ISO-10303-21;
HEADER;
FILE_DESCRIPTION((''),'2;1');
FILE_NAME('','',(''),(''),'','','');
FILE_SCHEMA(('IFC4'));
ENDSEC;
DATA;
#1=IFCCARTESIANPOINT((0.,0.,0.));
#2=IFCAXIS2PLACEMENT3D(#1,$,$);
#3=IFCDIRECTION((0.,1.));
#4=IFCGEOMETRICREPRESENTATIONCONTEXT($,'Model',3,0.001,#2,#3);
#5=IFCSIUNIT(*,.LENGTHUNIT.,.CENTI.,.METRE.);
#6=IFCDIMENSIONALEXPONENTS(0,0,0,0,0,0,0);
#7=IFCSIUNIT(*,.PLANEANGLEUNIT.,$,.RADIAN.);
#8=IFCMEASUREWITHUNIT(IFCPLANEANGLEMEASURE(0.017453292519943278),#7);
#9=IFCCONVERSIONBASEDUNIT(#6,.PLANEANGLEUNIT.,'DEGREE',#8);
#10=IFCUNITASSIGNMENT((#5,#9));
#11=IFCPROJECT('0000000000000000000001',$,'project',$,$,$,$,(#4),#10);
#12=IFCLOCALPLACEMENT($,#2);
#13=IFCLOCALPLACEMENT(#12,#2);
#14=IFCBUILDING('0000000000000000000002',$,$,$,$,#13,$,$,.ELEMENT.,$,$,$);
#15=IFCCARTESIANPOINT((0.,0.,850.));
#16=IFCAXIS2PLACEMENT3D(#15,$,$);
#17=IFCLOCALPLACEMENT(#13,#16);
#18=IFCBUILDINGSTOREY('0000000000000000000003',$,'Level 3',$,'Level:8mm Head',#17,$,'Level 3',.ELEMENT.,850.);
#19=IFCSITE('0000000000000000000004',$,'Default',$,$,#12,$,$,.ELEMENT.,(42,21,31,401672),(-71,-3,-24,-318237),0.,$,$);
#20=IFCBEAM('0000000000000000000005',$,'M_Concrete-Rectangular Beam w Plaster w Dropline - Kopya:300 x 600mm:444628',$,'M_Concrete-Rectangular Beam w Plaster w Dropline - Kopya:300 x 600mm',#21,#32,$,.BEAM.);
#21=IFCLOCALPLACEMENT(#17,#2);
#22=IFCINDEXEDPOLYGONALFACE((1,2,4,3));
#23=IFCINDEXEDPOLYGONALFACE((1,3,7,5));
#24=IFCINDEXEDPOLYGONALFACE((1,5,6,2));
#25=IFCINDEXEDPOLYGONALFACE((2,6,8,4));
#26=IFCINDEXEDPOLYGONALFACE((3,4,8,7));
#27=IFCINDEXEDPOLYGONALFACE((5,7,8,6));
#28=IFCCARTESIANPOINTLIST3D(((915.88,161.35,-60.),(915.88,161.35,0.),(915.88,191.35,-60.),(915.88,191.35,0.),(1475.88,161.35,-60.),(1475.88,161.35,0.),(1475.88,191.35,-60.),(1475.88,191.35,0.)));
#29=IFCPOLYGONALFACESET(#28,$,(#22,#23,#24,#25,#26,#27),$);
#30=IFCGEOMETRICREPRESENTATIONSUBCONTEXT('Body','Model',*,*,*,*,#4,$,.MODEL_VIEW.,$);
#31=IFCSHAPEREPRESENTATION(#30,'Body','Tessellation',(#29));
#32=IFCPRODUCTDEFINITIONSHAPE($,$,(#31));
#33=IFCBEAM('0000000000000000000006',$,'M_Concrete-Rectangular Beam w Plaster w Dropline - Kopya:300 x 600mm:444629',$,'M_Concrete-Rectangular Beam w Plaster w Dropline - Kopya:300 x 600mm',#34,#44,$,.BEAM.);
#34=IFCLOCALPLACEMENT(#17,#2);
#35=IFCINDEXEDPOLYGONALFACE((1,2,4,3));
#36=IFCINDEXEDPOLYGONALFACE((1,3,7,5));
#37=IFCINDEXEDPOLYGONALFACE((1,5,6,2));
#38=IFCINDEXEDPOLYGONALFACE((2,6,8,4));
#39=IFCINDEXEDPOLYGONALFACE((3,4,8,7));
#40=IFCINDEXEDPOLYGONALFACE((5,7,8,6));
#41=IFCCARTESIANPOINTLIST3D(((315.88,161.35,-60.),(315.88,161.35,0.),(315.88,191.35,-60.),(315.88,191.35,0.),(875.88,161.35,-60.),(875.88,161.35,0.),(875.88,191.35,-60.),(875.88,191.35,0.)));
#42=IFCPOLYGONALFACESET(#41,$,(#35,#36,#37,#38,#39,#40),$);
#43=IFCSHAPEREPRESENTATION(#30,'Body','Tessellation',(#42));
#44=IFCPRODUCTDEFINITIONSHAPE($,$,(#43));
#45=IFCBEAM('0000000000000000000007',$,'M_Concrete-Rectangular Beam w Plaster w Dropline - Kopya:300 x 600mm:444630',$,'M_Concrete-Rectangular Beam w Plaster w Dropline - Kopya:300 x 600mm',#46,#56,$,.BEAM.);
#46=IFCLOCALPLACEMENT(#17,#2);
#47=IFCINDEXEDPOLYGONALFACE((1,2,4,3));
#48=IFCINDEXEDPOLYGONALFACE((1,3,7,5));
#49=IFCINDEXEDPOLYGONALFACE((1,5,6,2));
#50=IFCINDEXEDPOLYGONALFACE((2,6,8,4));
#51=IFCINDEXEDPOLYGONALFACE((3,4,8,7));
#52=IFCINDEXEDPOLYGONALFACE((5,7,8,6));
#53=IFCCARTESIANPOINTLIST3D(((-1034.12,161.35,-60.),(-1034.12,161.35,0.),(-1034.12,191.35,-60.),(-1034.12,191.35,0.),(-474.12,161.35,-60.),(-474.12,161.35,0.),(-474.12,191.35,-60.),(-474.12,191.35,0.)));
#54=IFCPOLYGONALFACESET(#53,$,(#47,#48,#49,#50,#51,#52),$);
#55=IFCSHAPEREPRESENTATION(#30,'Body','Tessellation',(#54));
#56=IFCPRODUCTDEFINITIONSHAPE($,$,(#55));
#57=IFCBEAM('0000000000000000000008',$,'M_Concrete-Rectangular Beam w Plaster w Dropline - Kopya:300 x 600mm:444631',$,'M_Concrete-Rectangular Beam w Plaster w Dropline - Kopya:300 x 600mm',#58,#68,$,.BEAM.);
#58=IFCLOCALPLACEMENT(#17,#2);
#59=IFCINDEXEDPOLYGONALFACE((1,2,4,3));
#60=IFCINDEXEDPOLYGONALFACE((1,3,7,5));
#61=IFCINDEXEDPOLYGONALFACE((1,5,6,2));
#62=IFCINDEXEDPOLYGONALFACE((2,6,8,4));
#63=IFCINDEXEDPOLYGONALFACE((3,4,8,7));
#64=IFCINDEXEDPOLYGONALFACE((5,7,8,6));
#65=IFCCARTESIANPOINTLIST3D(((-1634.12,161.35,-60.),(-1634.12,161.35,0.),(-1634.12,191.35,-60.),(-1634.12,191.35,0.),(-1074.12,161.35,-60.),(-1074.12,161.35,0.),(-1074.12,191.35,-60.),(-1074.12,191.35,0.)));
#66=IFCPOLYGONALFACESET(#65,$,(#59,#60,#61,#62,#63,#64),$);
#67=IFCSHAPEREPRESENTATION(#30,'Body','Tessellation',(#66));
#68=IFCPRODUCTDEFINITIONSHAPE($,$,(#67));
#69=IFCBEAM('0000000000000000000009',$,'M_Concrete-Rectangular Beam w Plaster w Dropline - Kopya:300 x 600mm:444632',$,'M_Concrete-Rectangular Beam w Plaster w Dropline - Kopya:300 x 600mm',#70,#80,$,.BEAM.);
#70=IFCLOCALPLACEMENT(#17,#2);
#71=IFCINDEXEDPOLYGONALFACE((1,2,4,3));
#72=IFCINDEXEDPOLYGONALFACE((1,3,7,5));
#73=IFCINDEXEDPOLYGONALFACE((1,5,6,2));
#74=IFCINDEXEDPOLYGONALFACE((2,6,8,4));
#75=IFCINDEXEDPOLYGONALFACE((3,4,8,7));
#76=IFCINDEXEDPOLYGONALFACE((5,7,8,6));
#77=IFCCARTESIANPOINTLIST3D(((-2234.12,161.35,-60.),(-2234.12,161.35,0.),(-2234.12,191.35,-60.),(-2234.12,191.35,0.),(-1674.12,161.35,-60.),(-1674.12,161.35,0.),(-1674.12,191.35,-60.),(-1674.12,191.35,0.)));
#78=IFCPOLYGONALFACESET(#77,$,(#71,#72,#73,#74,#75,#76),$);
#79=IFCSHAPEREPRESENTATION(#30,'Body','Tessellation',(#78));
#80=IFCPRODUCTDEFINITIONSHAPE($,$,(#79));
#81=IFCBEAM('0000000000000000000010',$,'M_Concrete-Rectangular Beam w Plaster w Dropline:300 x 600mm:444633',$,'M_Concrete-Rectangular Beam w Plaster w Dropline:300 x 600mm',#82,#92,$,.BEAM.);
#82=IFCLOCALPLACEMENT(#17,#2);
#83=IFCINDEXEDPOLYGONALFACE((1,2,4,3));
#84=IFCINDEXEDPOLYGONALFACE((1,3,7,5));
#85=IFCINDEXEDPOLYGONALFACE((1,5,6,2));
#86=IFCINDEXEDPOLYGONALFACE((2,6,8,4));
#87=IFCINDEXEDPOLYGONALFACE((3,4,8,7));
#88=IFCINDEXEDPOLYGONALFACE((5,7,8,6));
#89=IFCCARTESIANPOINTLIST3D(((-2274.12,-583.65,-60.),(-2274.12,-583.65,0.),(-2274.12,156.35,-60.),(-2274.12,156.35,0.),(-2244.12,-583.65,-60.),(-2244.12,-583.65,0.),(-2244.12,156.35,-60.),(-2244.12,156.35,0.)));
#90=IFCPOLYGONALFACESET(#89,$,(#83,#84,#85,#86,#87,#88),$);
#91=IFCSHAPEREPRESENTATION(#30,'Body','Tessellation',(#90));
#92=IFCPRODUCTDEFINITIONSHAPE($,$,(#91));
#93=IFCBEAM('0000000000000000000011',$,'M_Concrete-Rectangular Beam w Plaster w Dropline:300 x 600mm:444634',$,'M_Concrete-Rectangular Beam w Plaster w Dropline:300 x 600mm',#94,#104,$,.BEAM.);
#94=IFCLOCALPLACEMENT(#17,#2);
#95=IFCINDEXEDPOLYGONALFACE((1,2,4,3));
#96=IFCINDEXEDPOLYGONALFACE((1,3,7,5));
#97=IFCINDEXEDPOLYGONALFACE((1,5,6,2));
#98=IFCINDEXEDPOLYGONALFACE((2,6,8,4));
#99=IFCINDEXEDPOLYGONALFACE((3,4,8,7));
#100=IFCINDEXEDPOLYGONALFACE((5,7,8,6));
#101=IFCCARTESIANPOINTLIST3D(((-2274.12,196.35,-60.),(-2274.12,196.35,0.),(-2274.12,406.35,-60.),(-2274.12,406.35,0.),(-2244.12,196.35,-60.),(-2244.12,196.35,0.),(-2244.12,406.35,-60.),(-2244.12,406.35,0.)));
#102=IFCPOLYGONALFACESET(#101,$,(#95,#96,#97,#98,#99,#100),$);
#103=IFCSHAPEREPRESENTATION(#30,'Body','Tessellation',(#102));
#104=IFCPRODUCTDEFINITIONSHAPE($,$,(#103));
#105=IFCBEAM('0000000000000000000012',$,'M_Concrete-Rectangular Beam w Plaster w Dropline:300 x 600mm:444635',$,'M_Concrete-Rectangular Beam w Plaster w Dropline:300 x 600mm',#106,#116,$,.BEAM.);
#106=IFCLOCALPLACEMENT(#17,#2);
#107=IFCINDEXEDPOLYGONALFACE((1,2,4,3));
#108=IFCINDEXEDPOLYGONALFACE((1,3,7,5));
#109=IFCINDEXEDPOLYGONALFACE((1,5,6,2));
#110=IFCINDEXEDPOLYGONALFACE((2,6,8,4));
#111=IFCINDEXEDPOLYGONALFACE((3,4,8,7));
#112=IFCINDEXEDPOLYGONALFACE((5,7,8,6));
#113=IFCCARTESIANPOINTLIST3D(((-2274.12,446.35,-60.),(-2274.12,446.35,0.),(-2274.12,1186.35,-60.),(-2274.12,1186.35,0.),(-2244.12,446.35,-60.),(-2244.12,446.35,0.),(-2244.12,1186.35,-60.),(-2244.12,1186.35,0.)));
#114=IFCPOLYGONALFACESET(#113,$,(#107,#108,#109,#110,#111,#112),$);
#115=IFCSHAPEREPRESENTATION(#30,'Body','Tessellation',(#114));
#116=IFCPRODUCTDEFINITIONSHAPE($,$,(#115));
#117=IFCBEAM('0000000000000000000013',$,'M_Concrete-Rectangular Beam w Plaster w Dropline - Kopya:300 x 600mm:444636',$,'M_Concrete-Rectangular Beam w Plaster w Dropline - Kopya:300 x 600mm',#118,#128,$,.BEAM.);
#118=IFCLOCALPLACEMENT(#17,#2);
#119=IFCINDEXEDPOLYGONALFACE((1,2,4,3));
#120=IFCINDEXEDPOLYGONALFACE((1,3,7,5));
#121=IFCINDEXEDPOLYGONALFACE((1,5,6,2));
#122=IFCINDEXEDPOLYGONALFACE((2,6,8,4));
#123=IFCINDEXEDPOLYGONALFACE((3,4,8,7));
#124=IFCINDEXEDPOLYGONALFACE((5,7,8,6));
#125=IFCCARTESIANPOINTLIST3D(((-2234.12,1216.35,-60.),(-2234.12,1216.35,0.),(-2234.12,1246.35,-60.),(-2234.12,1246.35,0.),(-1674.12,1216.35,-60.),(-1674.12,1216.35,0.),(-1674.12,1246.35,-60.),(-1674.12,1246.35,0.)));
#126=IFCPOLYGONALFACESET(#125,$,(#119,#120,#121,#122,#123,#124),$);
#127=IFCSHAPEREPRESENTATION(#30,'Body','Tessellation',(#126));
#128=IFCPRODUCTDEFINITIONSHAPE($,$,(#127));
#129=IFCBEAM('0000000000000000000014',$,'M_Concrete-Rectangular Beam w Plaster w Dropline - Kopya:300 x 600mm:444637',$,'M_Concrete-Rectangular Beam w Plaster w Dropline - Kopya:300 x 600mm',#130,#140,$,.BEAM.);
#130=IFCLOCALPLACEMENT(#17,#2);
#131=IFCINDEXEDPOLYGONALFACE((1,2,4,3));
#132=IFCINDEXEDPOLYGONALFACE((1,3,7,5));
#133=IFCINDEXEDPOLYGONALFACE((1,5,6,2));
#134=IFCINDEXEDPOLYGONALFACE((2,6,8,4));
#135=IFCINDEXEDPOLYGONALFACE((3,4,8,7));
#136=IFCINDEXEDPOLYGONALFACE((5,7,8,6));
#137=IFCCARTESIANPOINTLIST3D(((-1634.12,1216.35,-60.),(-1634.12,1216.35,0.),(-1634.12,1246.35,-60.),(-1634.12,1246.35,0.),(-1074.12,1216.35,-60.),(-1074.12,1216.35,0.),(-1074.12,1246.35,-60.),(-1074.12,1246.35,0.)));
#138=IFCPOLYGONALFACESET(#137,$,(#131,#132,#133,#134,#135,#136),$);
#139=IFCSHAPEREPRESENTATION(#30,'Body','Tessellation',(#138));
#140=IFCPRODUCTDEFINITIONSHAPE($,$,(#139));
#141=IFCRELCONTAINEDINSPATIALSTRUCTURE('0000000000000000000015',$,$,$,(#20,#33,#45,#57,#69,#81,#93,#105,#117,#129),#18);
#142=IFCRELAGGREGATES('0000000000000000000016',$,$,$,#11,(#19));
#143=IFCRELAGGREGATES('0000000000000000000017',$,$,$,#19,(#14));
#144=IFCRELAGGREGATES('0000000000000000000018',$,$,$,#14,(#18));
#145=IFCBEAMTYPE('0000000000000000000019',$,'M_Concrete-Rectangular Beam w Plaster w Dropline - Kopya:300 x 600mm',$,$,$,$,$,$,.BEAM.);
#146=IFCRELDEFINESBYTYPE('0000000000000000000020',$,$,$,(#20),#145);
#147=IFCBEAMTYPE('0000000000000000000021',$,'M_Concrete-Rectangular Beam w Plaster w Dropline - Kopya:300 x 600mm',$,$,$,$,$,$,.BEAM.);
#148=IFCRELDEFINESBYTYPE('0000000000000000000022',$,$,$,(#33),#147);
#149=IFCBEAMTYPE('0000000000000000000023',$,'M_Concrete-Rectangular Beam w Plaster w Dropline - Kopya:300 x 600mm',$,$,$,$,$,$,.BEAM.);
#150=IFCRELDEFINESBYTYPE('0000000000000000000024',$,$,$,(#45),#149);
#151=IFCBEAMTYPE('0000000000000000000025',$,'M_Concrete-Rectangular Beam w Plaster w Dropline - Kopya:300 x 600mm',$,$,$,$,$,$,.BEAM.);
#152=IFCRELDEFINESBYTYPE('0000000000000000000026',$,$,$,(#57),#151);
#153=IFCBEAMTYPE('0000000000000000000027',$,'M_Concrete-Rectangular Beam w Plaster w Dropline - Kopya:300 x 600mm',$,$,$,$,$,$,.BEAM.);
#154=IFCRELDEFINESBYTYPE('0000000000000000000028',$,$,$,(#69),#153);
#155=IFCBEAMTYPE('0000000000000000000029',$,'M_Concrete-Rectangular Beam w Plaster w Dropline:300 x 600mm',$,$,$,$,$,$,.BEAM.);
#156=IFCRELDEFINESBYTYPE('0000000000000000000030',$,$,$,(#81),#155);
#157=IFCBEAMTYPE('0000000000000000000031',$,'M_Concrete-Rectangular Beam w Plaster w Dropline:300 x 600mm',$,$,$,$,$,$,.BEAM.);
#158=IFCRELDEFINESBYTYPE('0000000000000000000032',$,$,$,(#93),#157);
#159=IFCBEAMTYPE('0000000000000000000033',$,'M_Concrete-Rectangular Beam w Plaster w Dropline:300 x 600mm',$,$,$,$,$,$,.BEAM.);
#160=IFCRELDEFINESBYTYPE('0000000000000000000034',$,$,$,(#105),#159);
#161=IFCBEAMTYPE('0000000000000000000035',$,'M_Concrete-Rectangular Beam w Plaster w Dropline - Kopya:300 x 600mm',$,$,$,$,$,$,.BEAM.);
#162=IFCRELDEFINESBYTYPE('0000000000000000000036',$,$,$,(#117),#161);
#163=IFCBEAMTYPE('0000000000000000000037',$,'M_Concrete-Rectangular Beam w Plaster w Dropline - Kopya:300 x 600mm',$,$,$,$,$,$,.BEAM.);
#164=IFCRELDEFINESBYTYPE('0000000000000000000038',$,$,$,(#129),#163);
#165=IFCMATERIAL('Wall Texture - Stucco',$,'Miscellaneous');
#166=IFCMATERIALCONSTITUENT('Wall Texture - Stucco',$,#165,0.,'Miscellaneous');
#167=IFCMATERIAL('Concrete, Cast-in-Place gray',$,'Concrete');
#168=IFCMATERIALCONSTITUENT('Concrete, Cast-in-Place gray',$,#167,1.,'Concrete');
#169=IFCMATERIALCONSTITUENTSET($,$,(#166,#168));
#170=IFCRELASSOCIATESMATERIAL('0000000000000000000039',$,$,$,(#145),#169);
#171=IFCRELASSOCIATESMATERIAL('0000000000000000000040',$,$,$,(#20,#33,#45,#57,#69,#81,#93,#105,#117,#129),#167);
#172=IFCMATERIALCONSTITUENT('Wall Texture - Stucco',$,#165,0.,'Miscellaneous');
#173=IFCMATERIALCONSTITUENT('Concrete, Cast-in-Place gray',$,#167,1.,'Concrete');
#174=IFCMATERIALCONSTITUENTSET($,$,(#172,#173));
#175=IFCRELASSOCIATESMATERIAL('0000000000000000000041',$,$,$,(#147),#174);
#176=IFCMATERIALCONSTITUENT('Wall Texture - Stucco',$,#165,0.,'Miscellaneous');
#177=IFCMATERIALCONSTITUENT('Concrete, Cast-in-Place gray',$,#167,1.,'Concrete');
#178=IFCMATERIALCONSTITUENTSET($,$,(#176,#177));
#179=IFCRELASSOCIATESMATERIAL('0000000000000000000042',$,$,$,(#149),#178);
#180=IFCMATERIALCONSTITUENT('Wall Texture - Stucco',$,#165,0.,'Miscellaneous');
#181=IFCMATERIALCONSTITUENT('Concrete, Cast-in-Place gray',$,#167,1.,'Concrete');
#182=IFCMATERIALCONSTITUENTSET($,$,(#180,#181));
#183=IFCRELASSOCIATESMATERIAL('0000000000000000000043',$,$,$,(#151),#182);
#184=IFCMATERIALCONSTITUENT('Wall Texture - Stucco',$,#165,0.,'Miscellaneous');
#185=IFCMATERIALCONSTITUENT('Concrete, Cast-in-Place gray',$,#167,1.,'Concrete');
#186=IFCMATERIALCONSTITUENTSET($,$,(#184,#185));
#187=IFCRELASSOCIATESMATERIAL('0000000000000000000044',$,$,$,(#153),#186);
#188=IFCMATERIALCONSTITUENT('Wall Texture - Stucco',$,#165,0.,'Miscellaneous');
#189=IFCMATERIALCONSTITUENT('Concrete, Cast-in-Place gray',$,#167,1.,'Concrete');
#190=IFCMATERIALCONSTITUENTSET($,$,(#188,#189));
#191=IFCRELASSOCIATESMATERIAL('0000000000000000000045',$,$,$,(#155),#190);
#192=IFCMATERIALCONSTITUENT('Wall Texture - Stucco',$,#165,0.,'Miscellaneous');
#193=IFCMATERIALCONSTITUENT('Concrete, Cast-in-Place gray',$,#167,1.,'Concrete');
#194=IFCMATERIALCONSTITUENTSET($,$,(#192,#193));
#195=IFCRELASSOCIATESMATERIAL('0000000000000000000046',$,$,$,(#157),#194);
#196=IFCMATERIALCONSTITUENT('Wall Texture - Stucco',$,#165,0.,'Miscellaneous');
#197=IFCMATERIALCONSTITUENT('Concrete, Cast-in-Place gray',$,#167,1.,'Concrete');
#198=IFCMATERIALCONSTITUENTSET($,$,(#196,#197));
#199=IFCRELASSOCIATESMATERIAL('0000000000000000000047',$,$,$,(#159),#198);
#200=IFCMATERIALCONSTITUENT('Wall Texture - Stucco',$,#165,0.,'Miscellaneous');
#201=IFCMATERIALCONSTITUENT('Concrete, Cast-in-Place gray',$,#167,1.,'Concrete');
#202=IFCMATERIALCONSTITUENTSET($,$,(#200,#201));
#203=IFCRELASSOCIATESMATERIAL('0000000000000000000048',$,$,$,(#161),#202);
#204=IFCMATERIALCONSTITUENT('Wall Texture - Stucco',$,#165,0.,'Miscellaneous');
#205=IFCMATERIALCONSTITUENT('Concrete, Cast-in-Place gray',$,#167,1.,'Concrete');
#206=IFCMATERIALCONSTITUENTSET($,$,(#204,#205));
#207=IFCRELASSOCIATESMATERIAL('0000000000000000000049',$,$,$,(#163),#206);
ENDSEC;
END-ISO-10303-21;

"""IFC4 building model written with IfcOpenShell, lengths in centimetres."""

from ifc_helpers import new_model, entity, si_unit, converted_unit, direction, frame, origin, place, context, subcontext, project, spatial, indexed_curve, outline, extrude, source, transform, mapped, material, constituent, constituent_set, type_object, type_shapes, element, save


model = new_model("IFC4")

# Units and contexts
model_context = context("Model", 3, precision=0.001, world=origin(), true_north=direction((0.0, 1.0)))
body_context = subcontext(model_context, "Body", "Model", "MODEL_VIEW")
ifc_project = project(units=[si_unit("LENGTHUNIT", "METRE", prefix="CENTI"), converted_unit("PLANEANGLEUNIT", "DEGREE", entity("IfcPlaneAngleMeasure", 0.017453292519943278), si_unit("PLANEANGLEUNIT", "RADIAN"), dimensions=[0, 0, 0, 0, 0, 0, 0])], contexts=[model_context])

# Site, building, storey
site_placement = place(None, origin())
site = spatial("IfcSite", under=ifc_project, at=site_placement, Name="Default", CompositionType="ELEMENT", RefLatitude=(42, 21, 31, 401672), RefLongitude=(-71, -3, -24, -318237), RefElevation=0.0)
building_placement = place(site_placement, origin())
building = spatial("IfcBuilding", under=site, at=building_placement, CompositionType="ELEMENT")
storey_placement = place(building_placement, frame((0.0, 0.0, 850.0)))
storey = spatial("IfcBuildingStorey", under=building, at=storey_placement, Name="Level 3", ObjectType="Level:8mm Head", LongName="Level 3", CompositionType="ELEMENT", Elevation=850.0)

# Beams
ifc_material_1 = material(Name="Concrete, Cast-in-Place gray", Category="Concrete")
ifc_material_2 = material(Name="Wall Texture - Stucco", Category="Miscellaneous")
ifc_constituent_1 = constituent(ifc_material_2, Name="Wall Texture - Stucco", Category="Miscellaneous", fraction=0.0)
ifc_constituent_2 = constituent(ifc_material_1, Name="Concrete, Cast-in-Place gray", Category="Concrete", fraction=1.0)
ifc_constituent_set_1 = constituent_set(constituents=[ifc_constituent_1, ifc_constituent_2])
beam_type_1 = type_object("IfcBeamType", Name="M_Concrete-Rectangular Beam w Plaster w Dropline - Kopya:300 x 600mm", PredefinedType="BEAM", material=ifc_constituent_set_1)
shared_shape_1 = source(origin(), body_context, "Body", "SweptSolid", [
    extrude(outline(indexed_curve([(-30.0, -15.0), (30.0, -15.0), (30.0, 15.0), (-30.0, 15.0), (-30.0, -15.0)], self_intersect=False)), frame((1475.88, 176.35, 820.0), z_axis=(-1.0, 0.0, 0.0), x_axis=(0.0, 0.0, -1.0)), (0.0, 0.0, 1.0), 560.0),
])
type_shapes(beam_type_1, [shared_shape_1])
beam_1_placement = place(storey_placement, frame((0.0, 0.0, -850.0)))
element("IfcBeam", 1, at=beam_1_placement, inside=storey, type_object=beam_type_1, material=ifc_material_1, Name="M_Concrete-Rectangular Beam w Plaster w Dropline - Kopya:300 x 600mm:444628", ObjectType="M_Concrete-Rectangular Beam w Plaster w Dropline - Kopya:300 x 600mm", PredefinedType="BEAM", context=body_context, shape_type="MappedRepresentation", body=[
    mapped(shared_shape_1, transform((0.0, 0.0, 0.0), scale=1.0)),
])
ifc_constituent_3 = constituent(ifc_material_2, Name="Wall Texture - Stucco", Category="Miscellaneous", fraction=0.0)
ifc_constituent_4 = constituent(ifc_material_1, Name="Concrete, Cast-in-Place gray", Category="Concrete", fraction=1.0)
ifc_constituent_set_2 = constituent_set(constituents=[ifc_constituent_3, ifc_constituent_4])
beam_type_2 = type_object("IfcBeamType", Name="M_Concrete-Rectangular Beam w Plaster w Dropline - Kopya:300 x 600mm", PredefinedType="BEAM", material=ifc_constituent_set_2)
shared_shape_2 = source(origin(), body_context, "Body", "SweptSolid", [
    extrude(outline(indexed_curve([(-30.0, -15.0), (30.0, -15.0), (30.0, 15.0), (-30.0, 15.0), (-30.0, -15.0)], self_intersect=False)), frame((875.88, 176.35, 820.0), z_axis=(-1.0, 0.0, 0.0), x_axis=(0.0, 0.0, -1.0)), (0.0, 0.0, 1.0), 560.0),
])
type_shapes(beam_type_2, [shared_shape_2])
beam_2_placement = place(storey_placement, frame((0.0, 0.0, -850.0)))
element("IfcBeam", 2, at=beam_2_placement, inside=storey, type_object=beam_type_2, material=ifc_material_1, Name="M_Concrete-Rectangular Beam w Plaster w Dropline - Kopya:300 x 600mm:444629", ObjectType="M_Concrete-Rectangular Beam w Plaster w Dropline - Kopya:300 x 600mm", PredefinedType="BEAM", context=body_context, shape_type="MappedRepresentation", body=[
    mapped(shared_shape_2, transform((0.0, 0.0, 0.0), scale=1.0)),
])
ifc_constituent_5 = constituent(ifc_material_2, Name="Wall Texture - Stucco", Category="Miscellaneous", fraction=0.0)
ifc_constituent_6 = constituent(ifc_material_1, Name="Concrete, Cast-in-Place gray", Category="Concrete", fraction=1.0)
ifc_constituent_set_3 = constituent_set(constituents=[ifc_constituent_5, ifc_constituent_6])
beam_type_3 = type_object("IfcBeamType", Name="M_Concrete-Rectangular Beam w Plaster w Dropline - Kopya:300 x 600mm", PredefinedType="BEAM", material=ifc_constituent_set_3)
shared_shape_3 = source(origin(), body_context, "Body", "SweptSolid", [
    extrude(outline(indexed_curve([(-30.0, -15.0), (30.0, -15.0), (30.0, 15.0), (-30.0, 15.0), (-30.0, -15.0)], self_intersect=False)), frame((-474.12, 176.35, 820.0), z_axis=(-1.0, 0.0, 0.0), x_axis=(0.0, 0.0, -1.0)), (0.0, 0.0, 1.0), 560.0),
])
type_shapes(beam_type_3, [shared_shape_3])
beam_3_placement = place(storey_placement, frame((0.0, 0.0, -850.0)))
element("IfcBeam", 3, at=beam_3_placement, inside=storey, type_object=beam_type_3, material=ifc_material_1, Name="M_Concrete-Rectangular Beam w Plaster w Dropline - Kopya:300 x 600mm:444630", ObjectType="M_Concrete-Rectangular Beam w Plaster w Dropline - Kopya:300 x 600mm", PredefinedType="BEAM", context=body_context, shape_type="MappedRepresentation", body=[
    mapped(shared_shape_3, transform((0.0, 0.0, 0.0), scale=1.0)),
])
ifc_constituent_7 = constituent(ifc_material_2, Name="Wall Texture - Stucco", Category="Miscellaneous", fraction=0.0)
ifc_constituent_8 = constituent(ifc_material_1, Name="Concrete, Cast-in-Place gray", Category="Concrete", fraction=1.0)
ifc_constituent_set_4 = constituent_set(constituents=[ifc_constituent_7, ifc_constituent_8])
beam_type_4 = type_object("IfcBeamType", Name="M_Concrete-Rectangular Beam w Plaster w Dropline - Kopya:300 x 600mm", PredefinedType="BEAM", material=ifc_constituent_set_4)
shared_shape_4 = source(origin(), body_context, "Body", "SweptSolid", [
    extrude(outline(indexed_curve([(-30.0, -15.0), (30.0, -15.0), (30.0, 15.0), (-30.0, 15.0), (-30.0, -15.0)], self_intersect=False)), frame((-1074.12, 176.35, 820.0), z_axis=(-1.0, 0.0, 0.0), x_axis=(0.0, 0.0, -1.0)), (0.0, 0.0, 1.0), 560.0),
])
type_shapes(beam_type_4, [shared_shape_4])
beam_4_placement = place(storey_placement, frame((0.0, 0.0, -850.0)))
element("IfcBeam", 4, at=beam_4_placement, inside=storey, type_object=beam_type_4, material=ifc_material_1, Name="M_Concrete-Rectangular Beam w Plaster w Dropline - Kopya:300 x 600mm:444631", ObjectType="M_Concrete-Rectangular Beam w Plaster w Dropline - Kopya:300 x 600mm", PredefinedType="BEAM", context=body_context, shape_type="MappedRepresentation", body=[
    mapped(shared_shape_4, transform((0.0, 0.0, 0.0), scale=1.0)),
])
ifc_constituent_9 = constituent(ifc_material_2, Name="Wall Texture - Stucco", Category="Miscellaneous", fraction=0.0)
ifc_constituent_10 = constituent(ifc_material_1, Name="Concrete, Cast-in-Place gray", Category="Concrete", fraction=1.0)
ifc_constituent_set_5 = constituent_set(constituents=[ifc_constituent_9, ifc_constituent_10])
beam_type_5 = type_object("IfcBeamType", Name="M_Concrete-Rectangular Beam w Plaster w Dropline - Kopya:300 x 600mm", PredefinedType="BEAM", material=ifc_constituent_set_5)
shared_shape_5 = source(origin(), body_context, "Body", "SweptSolid", [
    extrude(outline(indexed_curve([(-30.0, -15.0), (30.0, -15.0), (30.0, 15.0), (-30.0, 15.0), (-30.0, -15.0)], self_intersect=False)), frame((-1674.12, 176.35, 820.0), z_axis=(-1.0, 0.0, 0.0), x_axis=(0.0, 0.0, -1.0)), (0.0, 0.0, 1.0), 560.0),
])
type_shapes(beam_type_5, [shared_shape_5])
beam_5_placement = place(storey_placement, frame((0.0, 0.0, -850.0)))
element("IfcBeam", 5, at=beam_5_placement, inside=storey, type_object=beam_type_5, material=ifc_material_1, Name="M_Concrete-Rectangular Beam w Plaster w Dropline - Kopya:300 x 600mm:444632", ObjectType="M_Concrete-Rectangular Beam w Plaster w Dropline - Kopya:300 x 600mm", PredefinedType="BEAM", context=body_context, shape_type="MappedRepresentation", body=[
    mapped(shared_shape_5, transform((0.0, 0.0, 0.0), scale=1.0)),
])
ifc_constituent_11 = constituent(ifc_material_2, Name="Wall Texture - Stucco", Category="Miscellaneous", fraction=0.0)
ifc_constituent_12 = constituent(ifc_material_1, Name="Concrete, Cast-in-Place gray", Category="Concrete", fraction=1.0)
ifc_constituent_set_6 = constituent_set(constituents=[ifc_constituent_11, ifc_constituent_12])
beam_type_6 = type_object("IfcBeamType", Name="M_Concrete-Rectangular Beam w Plaster w Dropline:300 x 600mm", PredefinedType="BEAM", material=ifc_constituent_set_6)
shared_shape_6 = source(origin(), body_context, "Body", "SweptSolid", [
    extrude(outline(indexed_curve([(-15.0, -30.0), (15.0, -30.0), (15.0, 30.0), (-15.0, 30.0), (-15.0, -30.0)], self_intersect=False)), frame((-2259.12, -583.65, 820.0), z_axis=(0.0, 1.0, 0.0), x_axis=(-1.0, 0.0, 0.0)), (0.0, 0.0, 1.0), 740.0),
])
type_shapes(beam_type_6, [shared_shape_6])
beam_6_placement = place(storey_placement, frame((0.0, 0.0, -850.0)))
element("IfcBeam", 6, at=beam_6_placement, inside=storey, type_object=beam_type_6, material=ifc_material_1, Name="M_Concrete-Rectangular Beam w Plaster w Dropline:300 x 600mm:444633", ObjectType="M_Concrete-Rectangular Beam w Plaster w Dropline:300 x 600mm", PredefinedType="BEAM", context=body_context, shape_type="MappedRepresentation", body=[
    mapped(shared_shape_6, transform((0.0, 0.0, 0.0), scale=1.0)),
])
ifc_constituent_13 = constituent(ifc_material_2, Name="Wall Texture - Stucco", Category="Miscellaneous", fraction=0.0)
ifc_constituent_14 = constituent(ifc_material_1, Name="Concrete, Cast-in-Place gray", Category="Concrete", fraction=1.0)
ifc_constituent_set_7 = constituent_set(constituents=[ifc_constituent_13, ifc_constituent_14])
beam_type_7 = type_object("IfcBeamType", Name="M_Concrete-Rectangular Beam w Plaster w Dropline:300 x 600mm", PredefinedType="BEAM", material=ifc_constituent_set_7)
shared_shape_7 = source(origin(), body_context, "Body", "SweptSolid", [
    extrude(outline(indexed_curve([(-15.0, -30.0), (15.0, -30.0), (15.0, 30.0), (-15.0, 30.0), (-15.0, -30.0)], self_intersect=False)), frame((-2259.12, 196.35, 820.0), z_axis=(0.0, 1.0, 0.0), x_axis=(-1.0, 0.0, 0.0)), (0.0, 0.0, 1.0), 210.0),
])
type_shapes(beam_type_7, [shared_shape_7])
beam_7_placement = place(storey_placement, frame((0.0, 0.0, -850.0)))
element("IfcBeam", 7, at=beam_7_placement, inside=storey, type_object=beam_type_7, material=ifc_material_1, Name="M_Concrete-Rectangular Beam w Plaster w Dropline:300 x 600mm:444634", ObjectType="M_Concrete-Rectangular Beam w Plaster w Dropline:300 x 600mm", PredefinedType="BEAM", context=body_context, shape_type="MappedRepresentation", body=[
    mapped(shared_shape_7, transform((0.0, 0.0, 0.0), scale=1.0)),
])
ifc_constituent_15 = constituent(ifc_material_2, Name="Wall Texture - Stucco", Category="Miscellaneous", fraction=0.0)
ifc_constituent_16 = constituent(ifc_material_1, Name="Concrete, Cast-in-Place gray", Category="Concrete", fraction=1.0)
ifc_constituent_set_8 = constituent_set(constituents=[ifc_constituent_15, ifc_constituent_16])
beam_type_8 = type_object("IfcBeamType", Name="M_Concrete-Rectangular Beam w Plaster w Dropline:300 x 600mm", PredefinedType="BEAM", material=ifc_constituent_set_8)
shared_shape_8 = source(origin(), body_context, "Body", "SweptSolid", [
    extrude(outline(indexed_curve([(-15.0, -30.0), (15.0, -30.0), (15.0, 30.0), (-15.0, 30.0), (-15.0, -30.0)], self_intersect=False)), frame((-2259.12, 446.35, 820.0), z_axis=(0.0, 1.0, 0.0), x_axis=(-1.0, 0.0, 0.0)), (0.0, 0.0, 1.0), 740.0),
])
type_shapes(beam_type_8, [shared_shape_8])
beam_8_placement = place(storey_placement, frame((0.0, 0.0, -850.0)))
element("IfcBeam", 8, at=beam_8_placement, inside=storey, type_object=beam_type_8, material=ifc_material_1, Name="M_Concrete-Rectangular Beam w Plaster w Dropline:300 x 600mm:444635", ObjectType="M_Concrete-Rectangular Beam w Plaster w Dropline:300 x 600mm", PredefinedType="BEAM", context=body_context, shape_type="MappedRepresentation", body=[
    mapped(shared_shape_8, transform((0.0, 0.0, 0.0), scale=1.0)),
])
ifc_constituent_17 = constituent(ifc_material_2, Name="Wall Texture - Stucco", Category="Miscellaneous", fraction=0.0)
ifc_constituent_18 = constituent(ifc_material_1, Name="Concrete, Cast-in-Place gray", Category="Concrete", fraction=1.0)
ifc_constituent_set_9 = constituent_set(constituents=[ifc_constituent_17, ifc_constituent_18])
beam_type_9 = type_object("IfcBeamType", Name="M_Concrete-Rectangular Beam w Plaster w Dropline - Kopya:300 x 600mm", PredefinedType="BEAM", material=ifc_constituent_set_9)
shared_shape_9 = source(origin(), body_context, "Body", "SweptSolid", [
    extrude(outline(indexed_curve([(-30.0, -15.0), (30.0, -15.0), (30.0, 15.0), (-30.0, 15.0), (-30.0, -15.0)], self_intersect=False)), frame((-2234.12, 1231.35, 820.0), z_axis=(1.0, 0.0, 0.0), x_axis=(0.0, 0.0, -1.0)), (0.0, 0.0, 1.0), 560.0),
])
type_shapes(beam_type_9, [shared_shape_9])
beam_9_placement = place(storey_placement, frame((0.0, 0.0, -850.0)))
element("IfcBeam", 9, at=beam_9_placement, inside=storey, type_object=beam_type_9, material=ifc_material_1, Name="M_Concrete-Rectangular Beam w Plaster w Dropline - Kopya:300 x 600mm:444636", ObjectType="M_Concrete-Rectangular Beam w Plaster w Dropline - Kopya:300 x 600mm", PredefinedType="BEAM", context=body_context, shape_type="MappedRepresentation", body=[
    mapped(shared_shape_9, transform((0.0, 0.0, 0.0), scale=1.0)),
])
ifc_constituent_19 = constituent(ifc_material_2, Name="Wall Texture - Stucco", Category="Miscellaneous", fraction=0.0)
ifc_constituent_20 = constituent(ifc_material_1, Name="Concrete, Cast-in-Place gray", Category="Concrete", fraction=1.0)
ifc_constituent_set_10 = constituent_set(constituents=[ifc_constituent_19, ifc_constituent_20])
beam_type_10 = type_object("IfcBeamType", Name="M_Concrete-Rectangular Beam w Plaster w Dropline - Kopya:300 x 600mm", PredefinedType="BEAM", material=ifc_constituent_set_10)
shared_shape_10 = source(origin(), body_context, "Body", "SweptSolid", [
    extrude(outline(indexed_curve([(-30.0, -15.0), (30.0, -15.0), (30.0, 15.0), (-30.0, 15.0), (-30.0, -15.0)], self_intersect=False)), frame((-1634.12, 1231.35, 820.0), z_axis=(1.0, 0.0, 0.0), x_axis=(0.0, 0.0, -1.0)), (0.0, 0.0, 1.0), 560.0),
])
type_shapes(beam_type_10, [shared_shape_10])
beam_10_placement = place(storey_placement, frame((0.0, 0.0, -850.0)))
element("IfcBeam", 10, at=beam_10_placement, inside=storey, type_object=beam_type_10, material=ifc_material_1, Name="M_Concrete-Rectangular Beam w Plaster w Dropline - Kopya:300 x 600mm:444637", ObjectType="M_Concrete-Rectangular Beam w Plaster w Dropline - Kopya:300 x 600mm", PredefinedType="BEAM", context=body_context, shape_type="MappedRepresentation", body=[
    mapped(shared_shape_10, transform((0.0, 0.0, 0.0), scale=1.0)),
])

save(model, "model.ifc")
